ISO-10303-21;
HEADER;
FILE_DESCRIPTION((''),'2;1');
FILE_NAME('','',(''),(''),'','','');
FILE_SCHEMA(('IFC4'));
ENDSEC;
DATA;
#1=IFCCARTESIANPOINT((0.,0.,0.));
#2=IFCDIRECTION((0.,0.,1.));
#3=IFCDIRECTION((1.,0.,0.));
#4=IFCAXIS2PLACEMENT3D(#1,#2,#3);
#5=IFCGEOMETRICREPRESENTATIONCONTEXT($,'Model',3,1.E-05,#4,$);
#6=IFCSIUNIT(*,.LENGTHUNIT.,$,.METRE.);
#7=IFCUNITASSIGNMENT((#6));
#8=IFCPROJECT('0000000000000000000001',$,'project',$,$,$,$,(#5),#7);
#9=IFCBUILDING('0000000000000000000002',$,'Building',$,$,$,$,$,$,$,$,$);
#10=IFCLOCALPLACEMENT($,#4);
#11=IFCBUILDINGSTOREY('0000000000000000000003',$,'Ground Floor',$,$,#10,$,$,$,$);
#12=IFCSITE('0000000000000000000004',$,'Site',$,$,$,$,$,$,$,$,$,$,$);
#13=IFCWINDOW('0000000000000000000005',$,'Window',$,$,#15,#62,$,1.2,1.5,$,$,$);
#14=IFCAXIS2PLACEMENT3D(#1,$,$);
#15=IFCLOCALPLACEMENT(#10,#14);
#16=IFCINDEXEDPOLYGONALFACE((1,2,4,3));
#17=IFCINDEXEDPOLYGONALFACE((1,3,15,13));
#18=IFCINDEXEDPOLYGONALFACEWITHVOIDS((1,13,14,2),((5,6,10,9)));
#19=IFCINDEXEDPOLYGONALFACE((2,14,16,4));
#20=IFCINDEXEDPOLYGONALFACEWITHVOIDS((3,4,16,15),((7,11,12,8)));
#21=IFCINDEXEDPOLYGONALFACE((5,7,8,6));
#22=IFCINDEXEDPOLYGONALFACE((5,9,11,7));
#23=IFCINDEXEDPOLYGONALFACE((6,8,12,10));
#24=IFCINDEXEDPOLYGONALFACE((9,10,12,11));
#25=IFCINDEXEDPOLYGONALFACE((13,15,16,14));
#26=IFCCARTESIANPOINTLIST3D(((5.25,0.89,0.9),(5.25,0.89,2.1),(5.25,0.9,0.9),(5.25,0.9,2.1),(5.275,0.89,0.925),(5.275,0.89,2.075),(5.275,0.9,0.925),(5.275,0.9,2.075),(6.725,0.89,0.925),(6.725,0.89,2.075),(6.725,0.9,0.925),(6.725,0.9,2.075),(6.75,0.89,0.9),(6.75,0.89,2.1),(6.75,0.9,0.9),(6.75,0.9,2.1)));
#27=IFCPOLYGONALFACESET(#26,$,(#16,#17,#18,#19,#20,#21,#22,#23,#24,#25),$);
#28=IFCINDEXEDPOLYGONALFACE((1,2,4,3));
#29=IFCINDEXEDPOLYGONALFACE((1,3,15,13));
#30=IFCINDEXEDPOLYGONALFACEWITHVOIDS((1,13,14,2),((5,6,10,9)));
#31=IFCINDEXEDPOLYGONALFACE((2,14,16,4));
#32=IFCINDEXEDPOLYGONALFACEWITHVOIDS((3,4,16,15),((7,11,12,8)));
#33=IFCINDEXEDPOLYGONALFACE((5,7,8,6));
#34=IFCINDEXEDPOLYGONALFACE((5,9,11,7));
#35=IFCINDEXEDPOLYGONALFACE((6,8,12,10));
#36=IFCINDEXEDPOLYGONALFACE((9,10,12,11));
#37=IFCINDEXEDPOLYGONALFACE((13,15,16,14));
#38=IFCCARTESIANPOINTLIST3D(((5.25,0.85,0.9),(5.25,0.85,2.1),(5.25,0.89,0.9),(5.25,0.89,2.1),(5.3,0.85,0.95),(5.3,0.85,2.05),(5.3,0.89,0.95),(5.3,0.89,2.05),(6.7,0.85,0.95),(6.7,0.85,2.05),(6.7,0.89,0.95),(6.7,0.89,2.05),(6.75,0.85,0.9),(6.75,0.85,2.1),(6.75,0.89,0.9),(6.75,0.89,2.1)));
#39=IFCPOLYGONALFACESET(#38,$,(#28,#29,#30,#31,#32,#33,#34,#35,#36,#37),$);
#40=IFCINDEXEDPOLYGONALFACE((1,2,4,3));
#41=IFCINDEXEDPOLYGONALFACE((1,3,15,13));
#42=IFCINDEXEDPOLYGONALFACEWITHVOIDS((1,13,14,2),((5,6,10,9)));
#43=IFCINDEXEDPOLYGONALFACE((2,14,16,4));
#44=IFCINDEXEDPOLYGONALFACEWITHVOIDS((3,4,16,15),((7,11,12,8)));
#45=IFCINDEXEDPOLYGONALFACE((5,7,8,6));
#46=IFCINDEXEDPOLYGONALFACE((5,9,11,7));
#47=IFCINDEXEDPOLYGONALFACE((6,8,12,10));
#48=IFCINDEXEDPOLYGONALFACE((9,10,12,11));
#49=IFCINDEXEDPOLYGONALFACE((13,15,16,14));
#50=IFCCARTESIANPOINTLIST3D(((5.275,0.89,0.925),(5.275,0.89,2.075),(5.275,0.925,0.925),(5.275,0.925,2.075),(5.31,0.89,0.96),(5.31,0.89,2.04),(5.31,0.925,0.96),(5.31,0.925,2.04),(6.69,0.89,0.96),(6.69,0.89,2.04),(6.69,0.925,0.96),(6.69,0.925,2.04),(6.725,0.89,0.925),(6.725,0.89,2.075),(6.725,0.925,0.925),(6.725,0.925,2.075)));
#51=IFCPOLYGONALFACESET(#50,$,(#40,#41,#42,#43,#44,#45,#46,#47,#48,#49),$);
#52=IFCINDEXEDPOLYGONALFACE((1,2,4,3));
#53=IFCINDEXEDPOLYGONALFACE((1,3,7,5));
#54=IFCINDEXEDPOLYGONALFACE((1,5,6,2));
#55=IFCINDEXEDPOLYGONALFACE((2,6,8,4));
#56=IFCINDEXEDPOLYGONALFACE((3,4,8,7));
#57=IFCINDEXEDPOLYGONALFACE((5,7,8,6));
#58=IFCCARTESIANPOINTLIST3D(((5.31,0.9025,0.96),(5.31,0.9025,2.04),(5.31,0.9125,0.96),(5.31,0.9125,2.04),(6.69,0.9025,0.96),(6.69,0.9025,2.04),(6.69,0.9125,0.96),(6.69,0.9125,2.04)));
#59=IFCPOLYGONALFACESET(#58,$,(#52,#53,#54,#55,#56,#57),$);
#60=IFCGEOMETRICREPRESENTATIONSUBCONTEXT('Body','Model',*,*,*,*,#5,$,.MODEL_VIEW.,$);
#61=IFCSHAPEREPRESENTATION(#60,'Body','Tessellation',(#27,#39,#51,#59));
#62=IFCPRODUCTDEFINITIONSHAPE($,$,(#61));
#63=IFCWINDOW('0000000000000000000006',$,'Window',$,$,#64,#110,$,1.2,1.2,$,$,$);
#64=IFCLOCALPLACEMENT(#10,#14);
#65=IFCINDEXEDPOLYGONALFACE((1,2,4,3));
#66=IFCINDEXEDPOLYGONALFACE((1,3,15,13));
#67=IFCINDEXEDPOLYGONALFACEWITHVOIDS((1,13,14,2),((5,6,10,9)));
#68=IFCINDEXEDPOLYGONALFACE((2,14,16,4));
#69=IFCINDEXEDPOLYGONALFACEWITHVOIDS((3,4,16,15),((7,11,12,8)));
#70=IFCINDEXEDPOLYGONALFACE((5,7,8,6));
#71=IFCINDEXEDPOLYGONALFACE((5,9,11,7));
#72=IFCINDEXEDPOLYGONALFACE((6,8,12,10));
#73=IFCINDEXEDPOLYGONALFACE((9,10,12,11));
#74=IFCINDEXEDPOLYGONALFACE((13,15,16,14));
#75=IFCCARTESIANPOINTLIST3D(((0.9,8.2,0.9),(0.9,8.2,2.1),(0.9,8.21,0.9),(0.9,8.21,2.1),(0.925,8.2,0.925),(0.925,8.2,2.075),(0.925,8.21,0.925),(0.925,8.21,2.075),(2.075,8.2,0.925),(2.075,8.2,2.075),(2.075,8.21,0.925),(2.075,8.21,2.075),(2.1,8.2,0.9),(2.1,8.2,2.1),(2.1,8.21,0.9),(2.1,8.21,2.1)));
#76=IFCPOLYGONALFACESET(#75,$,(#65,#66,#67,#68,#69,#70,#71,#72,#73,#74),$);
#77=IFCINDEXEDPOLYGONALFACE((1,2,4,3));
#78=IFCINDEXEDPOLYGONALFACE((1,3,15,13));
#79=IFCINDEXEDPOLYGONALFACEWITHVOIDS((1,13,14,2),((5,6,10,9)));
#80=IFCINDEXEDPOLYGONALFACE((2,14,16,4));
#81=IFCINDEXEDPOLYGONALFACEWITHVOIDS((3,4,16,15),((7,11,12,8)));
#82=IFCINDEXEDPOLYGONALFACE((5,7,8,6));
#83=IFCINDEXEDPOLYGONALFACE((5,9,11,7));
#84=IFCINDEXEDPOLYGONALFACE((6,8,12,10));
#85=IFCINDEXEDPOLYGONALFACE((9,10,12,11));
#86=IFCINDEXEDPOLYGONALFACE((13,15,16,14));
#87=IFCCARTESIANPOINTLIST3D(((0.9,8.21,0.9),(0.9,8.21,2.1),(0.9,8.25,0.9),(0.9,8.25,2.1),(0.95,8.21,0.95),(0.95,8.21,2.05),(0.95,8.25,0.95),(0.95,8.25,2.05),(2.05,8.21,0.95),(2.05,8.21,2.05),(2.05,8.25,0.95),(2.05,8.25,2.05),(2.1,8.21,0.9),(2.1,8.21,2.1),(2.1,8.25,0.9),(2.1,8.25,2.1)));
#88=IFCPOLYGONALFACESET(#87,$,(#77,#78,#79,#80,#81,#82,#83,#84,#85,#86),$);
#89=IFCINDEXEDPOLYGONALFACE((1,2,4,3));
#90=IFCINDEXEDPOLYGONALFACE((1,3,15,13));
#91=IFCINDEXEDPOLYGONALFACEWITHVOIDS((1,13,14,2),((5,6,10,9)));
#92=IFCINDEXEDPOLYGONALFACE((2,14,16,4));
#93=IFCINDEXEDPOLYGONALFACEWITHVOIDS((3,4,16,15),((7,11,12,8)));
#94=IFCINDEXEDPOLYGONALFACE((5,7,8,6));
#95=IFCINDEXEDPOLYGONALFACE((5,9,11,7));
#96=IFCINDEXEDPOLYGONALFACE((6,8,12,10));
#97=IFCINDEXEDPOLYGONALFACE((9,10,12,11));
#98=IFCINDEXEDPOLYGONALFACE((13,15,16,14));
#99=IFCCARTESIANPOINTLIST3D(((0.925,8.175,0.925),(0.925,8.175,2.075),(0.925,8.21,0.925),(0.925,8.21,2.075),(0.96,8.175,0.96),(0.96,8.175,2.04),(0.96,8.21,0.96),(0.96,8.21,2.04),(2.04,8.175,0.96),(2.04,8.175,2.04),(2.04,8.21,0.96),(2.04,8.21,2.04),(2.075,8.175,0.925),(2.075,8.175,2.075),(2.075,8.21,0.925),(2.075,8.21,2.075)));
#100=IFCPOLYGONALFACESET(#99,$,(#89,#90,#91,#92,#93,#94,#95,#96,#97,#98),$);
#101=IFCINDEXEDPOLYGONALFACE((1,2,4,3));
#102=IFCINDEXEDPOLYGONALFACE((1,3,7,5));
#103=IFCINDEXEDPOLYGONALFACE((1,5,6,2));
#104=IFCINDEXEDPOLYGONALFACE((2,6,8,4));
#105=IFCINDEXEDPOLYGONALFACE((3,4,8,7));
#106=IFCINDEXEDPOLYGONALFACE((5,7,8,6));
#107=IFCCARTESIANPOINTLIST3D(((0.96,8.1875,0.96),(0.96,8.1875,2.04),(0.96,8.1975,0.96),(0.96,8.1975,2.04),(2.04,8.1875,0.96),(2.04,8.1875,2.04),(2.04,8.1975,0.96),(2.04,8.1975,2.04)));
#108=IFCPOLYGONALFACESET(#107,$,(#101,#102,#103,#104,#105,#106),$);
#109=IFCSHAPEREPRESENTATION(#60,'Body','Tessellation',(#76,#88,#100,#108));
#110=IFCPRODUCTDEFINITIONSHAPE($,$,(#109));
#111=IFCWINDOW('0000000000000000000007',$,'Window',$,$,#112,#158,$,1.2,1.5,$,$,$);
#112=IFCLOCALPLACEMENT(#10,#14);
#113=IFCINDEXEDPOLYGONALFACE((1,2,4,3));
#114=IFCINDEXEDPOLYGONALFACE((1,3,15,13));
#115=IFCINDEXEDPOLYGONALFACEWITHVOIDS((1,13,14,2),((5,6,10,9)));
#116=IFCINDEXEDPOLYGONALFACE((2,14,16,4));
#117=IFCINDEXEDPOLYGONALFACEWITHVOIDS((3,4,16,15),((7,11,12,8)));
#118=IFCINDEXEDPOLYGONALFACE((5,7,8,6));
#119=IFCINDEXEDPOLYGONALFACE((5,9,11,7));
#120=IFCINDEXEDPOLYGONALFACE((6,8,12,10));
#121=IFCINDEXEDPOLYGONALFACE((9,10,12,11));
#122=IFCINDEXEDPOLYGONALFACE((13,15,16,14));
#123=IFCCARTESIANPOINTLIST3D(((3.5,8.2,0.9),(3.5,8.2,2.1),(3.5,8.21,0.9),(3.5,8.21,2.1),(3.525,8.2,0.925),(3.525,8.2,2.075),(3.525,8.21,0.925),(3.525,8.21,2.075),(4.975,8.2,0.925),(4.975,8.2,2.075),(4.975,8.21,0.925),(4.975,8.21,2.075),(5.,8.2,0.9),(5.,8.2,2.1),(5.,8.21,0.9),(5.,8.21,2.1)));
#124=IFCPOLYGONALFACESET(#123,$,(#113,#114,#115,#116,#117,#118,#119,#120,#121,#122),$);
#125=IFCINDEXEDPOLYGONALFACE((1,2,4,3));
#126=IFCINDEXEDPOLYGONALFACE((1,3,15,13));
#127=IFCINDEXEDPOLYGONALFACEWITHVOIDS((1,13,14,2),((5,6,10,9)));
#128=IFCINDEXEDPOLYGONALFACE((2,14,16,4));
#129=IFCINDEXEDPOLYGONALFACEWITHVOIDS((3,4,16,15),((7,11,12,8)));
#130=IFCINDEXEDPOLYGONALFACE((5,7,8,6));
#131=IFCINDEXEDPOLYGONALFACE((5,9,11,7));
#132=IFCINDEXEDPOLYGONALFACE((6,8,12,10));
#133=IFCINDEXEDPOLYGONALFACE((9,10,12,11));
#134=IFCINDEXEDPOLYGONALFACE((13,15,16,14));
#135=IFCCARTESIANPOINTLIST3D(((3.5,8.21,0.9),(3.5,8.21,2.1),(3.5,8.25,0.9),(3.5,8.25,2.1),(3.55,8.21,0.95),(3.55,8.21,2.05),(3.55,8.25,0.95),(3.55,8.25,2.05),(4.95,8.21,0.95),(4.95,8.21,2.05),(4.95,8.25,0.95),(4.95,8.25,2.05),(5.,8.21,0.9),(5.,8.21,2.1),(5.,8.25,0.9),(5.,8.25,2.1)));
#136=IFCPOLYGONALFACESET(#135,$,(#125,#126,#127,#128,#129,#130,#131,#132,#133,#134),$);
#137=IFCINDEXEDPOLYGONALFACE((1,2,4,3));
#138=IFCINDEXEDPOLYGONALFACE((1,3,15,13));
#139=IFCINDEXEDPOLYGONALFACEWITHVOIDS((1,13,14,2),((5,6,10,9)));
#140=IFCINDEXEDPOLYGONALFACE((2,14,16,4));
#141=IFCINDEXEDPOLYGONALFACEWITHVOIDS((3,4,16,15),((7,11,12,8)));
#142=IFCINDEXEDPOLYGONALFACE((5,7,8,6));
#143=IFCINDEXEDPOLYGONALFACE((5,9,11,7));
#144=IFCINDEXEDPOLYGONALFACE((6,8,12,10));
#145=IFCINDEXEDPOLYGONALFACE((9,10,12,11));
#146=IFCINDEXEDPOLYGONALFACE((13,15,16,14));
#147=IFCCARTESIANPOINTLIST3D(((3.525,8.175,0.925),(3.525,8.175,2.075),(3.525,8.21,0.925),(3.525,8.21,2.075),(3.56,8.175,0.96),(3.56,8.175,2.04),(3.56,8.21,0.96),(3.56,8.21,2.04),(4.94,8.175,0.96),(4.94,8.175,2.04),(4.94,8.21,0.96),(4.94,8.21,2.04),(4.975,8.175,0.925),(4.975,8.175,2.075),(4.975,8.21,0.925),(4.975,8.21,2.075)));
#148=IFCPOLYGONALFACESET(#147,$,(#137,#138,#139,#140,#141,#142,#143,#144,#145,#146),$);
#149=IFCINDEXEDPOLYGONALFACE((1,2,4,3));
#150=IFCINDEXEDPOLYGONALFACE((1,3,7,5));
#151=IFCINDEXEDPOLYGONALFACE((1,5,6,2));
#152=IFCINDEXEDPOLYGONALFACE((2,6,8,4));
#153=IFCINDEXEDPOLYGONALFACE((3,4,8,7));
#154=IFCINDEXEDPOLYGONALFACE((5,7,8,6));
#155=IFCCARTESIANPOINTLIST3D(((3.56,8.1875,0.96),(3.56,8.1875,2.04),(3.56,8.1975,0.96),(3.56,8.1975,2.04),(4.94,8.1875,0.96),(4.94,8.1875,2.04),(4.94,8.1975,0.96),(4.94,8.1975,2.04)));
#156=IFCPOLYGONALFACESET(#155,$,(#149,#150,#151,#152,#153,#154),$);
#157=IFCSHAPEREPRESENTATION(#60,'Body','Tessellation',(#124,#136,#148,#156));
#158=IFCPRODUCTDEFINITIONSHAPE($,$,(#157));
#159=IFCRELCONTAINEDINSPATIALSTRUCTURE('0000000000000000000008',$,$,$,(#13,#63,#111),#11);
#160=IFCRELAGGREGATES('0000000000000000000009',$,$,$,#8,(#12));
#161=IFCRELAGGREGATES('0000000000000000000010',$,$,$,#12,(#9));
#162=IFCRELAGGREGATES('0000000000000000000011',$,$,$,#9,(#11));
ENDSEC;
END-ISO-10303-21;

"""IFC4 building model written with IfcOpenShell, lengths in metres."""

from ifc_helpers import new_model, si_unit, frame, origin_with_axes, place, context, subcontext, project, spatial, line, indexed_curve, outline, extrude, element, save


model = new_model("IFC4")

# Units and contexts
model_context = context("Model", 3, precision=1e-05, world=origin_with_axes())
body_context = subcontext(model_context, "Body", "Model", "MODEL_VIEW")
ifc_project = project(units=[si_unit("LENGTHUNIT", "METRE")], contexts=[model_context])

# Site, building, storey
site = spatial("IfcSite", under=ifc_project, Name="Site")
building = spatial("IfcBuilding", under=site, Name="Building")
storey_placement = place(None, origin_with_axes())
storey = spatial("IfcBuildingStorey", under=building, at=storey_placement, Name="Ground Floor")

# Windows
for number, where, z_axis, x_axis, name in (
    (1, (5.25, 0.8, 0.9), (0.0, 0.0, 1.0), (1.0, 0.0, 0.0), "Window"),
):
    element("IfcWindow", number, at=place(storey_placement, frame(where, z_axis=z_axis, x_axis=x_axis)), inside=storey, Name=name, OverallHeight=1.2, OverallWidth=1.5, context=body_context, shape_type="SweptSolid", body=[
        extrude(outline(indexed_curve([(0.0, 0.0), (1.5, 0.0), (1.5, 1.2), (0.0, 1.2)], segments=[line(1, 2, 3, 4, 1)]), holes=[indexed_curve([(0.025, 0.025), (1.475, 0.025), (1.475, 1.175), (0.025, 1.175)], segments=[line(1, 2, 3, 4, 1)])]), frame((0.0, 0.09, 0.0), z_axis=(0.0, -1.0, 0.0), x_axis=(1.0, 0.0, 0.0)), (0.0, 0.0, -1.0), 0.01),
        extrude(outline(indexed_curve([(0.0, 0.0), (1.5, 0.0), (1.5, 1.2), (0.0, 1.2)], segments=[line(1, 2, 3, 4, 1)]), holes=[indexed_curve([(0.05, 0.05), (1.45, 0.05), (1.45, 1.15), (0.05, 1.15)], segments=[line(1, 2, 3, 4, 1)])]), frame((0.0, 0.05, 0.0), z_axis=(0.0, -1.0, 0.0), x_axis=(1.0, 0.0, 0.0)), (0.0, 0.0, -1.0), 0.04),
        extrude(outline(indexed_curve([(0.0, 0.0), (1.45, 0.0), (1.45, 1.15), (0.0, 1.15)], segments=[line(1, 2, 3, 4, 1)]), holes=[indexed_curve([(0.035, 0.035), (1.415, 0.035), (1.415, 1.115), (0.035, 1.115)], segments=[line(1, 2, 3, 4, 1)])]), frame((0.025, 0.09, 0.025), z_axis=(0.0, -1.0, 0.0), x_axis=(1.0, 0.0, 0.0)), (0.0, 0.0, -1.0), 0.035),
        extrude(outline(indexed_curve([(0.035, 0.035), (1.415, 0.035), (1.415, 1.115), (0.035, 1.115)], segments=[line(1, 2, 3, 4, 1)])), frame((0.025, 0.1025, 0.025), z_axis=(0.0, -1.0, 0.0), x_axis=(1.0, 0.0, 0.0)), (0.0, 0.0, -1.0), 0.01),
    ])
window_1_placement = place(storey_placement, frame((2.1, 8.3, 0.9), z_axis=(0.0, 0.0, 1.0), x_axis=(-1.0, 0.0, 0.0)))
element("IfcWindow", 2, at=window_1_placement, inside=storey, Name="Window", OverallHeight=1.2, OverallWidth=1.2, context=body_context, shape_type="SweptSolid", body=[
    extrude(outline(indexed_curve([(0.0, 0.0), (1.2, 0.0), (1.2, 1.2), (0.0, 1.2)], segments=[line(1, 2, 3, 4, 1)]), holes=[indexed_curve([(0.025, 0.025), (1.175, 0.025), (1.175, 1.175), (0.025, 1.175)], segments=[line(1, 2, 3, 4, 1)])]), frame((0.0, 0.09, 0.0), z_axis=(0.0, -1.0, 0.0), x_axis=(1.0, 0.0, 0.0)), (0.0, 0.0, -1.0), 0.01),
    extrude(outline(indexed_curve([(0.0, 0.0), (1.2, 0.0), (1.2, 1.2), (0.0, 1.2)], segments=[line(1, 2, 3, 4, 1)]), holes=[indexed_curve([(0.05, 0.05), (1.15, 0.05), (1.15, 1.15), (0.05, 1.15)], segments=[line(1, 2, 3, 4, 1)])]), frame((0.0, 0.05, 0.0), z_axis=(0.0, -1.0, 0.0), x_axis=(1.0, 0.0, 0.0)), (0.0, 0.0, -1.0), 0.04),
    extrude(outline(indexed_curve([(0.0, 0.0), (1.15, 0.0), (1.15, 1.15), (0.0, 1.15)], segments=[line(1, 2, 3, 4, 1)]), holes=[indexed_curve([(0.035, 0.035), (1.115, 0.035), (1.115, 1.115), (0.035, 1.115)], segments=[line(1, 2, 3, 4, 1)])]), frame((0.025, 0.09, 0.025), z_axis=(0.0, -1.0, 0.0), x_axis=(1.0, 0.0, 0.0)), (0.0, 0.0, -1.0), 0.035),
    extrude(outline(indexed_curve([(0.035, 0.035), (1.115, 0.035), (1.115, 1.115), (0.035, 1.115)], segments=[line(1, 2, 3, 4, 1)])), frame((0.025, 0.1025, 0.025), z_axis=(0.0, -1.0, 0.0), x_axis=(1.0, 0.0, 0.0)), (0.0, 0.0, -1.0), 0.01),
])
window_2_placement = place(storey_placement, frame((5.0, 8.3, 0.9), z_axis=(0.0, 0.0, 1.0), x_axis=(-1.0, 0.0, 0.0)))
element("IfcWindow", 3, at=window_2_placement, inside=storey, Name="Window", OverallHeight=1.2, OverallWidth=1.5, context=body_context, shape_type="SweptSolid", body=[
    extrude(outline(indexed_curve([(0.0, 0.0), (1.5, 0.0), (1.5, 1.2), (0.0, 1.2)], segments=[line(1, 2, 3, 4, 1)]), holes=[indexed_curve([(0.025, 0.025), (1.475, 0.025), (1.475, 1.175), (0.025, 1.175)], segments=[line(1, 2, 3, 4, 1)])]), frame((0.0, 0.09, 0.0), z_axis=(0.0, -1.0, 0.0), x_axis=(1.0, 0.0, 0.0)), (0.0, 0.0, -1.0), 0.01),
    extrude(outline(indexed_curve([(0.0, 0.0), (1.5, 0.0), (1.5, 1.2), (0.0, 1.2)], segments=[line(1, 2, 3, 4, 1)]), holes=[indexed_curve([(0.05, 0.05), (1.45, 0.05), (1.45, 1.15), (0.05, 1.15)], segments=[line(1, 2, 3, 4, 1)])]), frame((0.0, 0.05, 0.0), z_axis=(0.0, -1.0, 0.0), x_axis=(1.0, 0.0, 0.0)), (0.0, 0.0, -1.0), 0.04),
    extrude(outline(indexed_curve([(0.0, 0.0), (1.45, 0.0), (1.45, 1.15), (0.0, 1.15)], segments=[line(1, 2, 3, 4, 1)]), holes=[indexed_curve([(0.035, 0.035), (1.415, 0.035), (1.415, 1.115), (0.035, 1.115)], segments=[line(1, 2, 3, 4, 1)])]), frame((0.025, 0.09, 0.025), z_axis=(0.0, -1.0, 0.0), x_axis=(1.0, 0.0, 0.0)), (0.0, 0.0, -1.0), 0.035),
    extrude(outline(indexed_curve([(0.035, 0.035), (1.415, 0.035), (1.415, 1.115), (0.035, 1.115)], segments=[line(1, 2, 3, 4, 1)])), frame((0.025, 0.1025, 0.025), z_axis=(0.0, -1.0, 0.0), x_axis=(1.0, 0.0, 0.0)), (0.0, 0.0, -1.0), 0.01),
])

save(model, "model.ifc")
